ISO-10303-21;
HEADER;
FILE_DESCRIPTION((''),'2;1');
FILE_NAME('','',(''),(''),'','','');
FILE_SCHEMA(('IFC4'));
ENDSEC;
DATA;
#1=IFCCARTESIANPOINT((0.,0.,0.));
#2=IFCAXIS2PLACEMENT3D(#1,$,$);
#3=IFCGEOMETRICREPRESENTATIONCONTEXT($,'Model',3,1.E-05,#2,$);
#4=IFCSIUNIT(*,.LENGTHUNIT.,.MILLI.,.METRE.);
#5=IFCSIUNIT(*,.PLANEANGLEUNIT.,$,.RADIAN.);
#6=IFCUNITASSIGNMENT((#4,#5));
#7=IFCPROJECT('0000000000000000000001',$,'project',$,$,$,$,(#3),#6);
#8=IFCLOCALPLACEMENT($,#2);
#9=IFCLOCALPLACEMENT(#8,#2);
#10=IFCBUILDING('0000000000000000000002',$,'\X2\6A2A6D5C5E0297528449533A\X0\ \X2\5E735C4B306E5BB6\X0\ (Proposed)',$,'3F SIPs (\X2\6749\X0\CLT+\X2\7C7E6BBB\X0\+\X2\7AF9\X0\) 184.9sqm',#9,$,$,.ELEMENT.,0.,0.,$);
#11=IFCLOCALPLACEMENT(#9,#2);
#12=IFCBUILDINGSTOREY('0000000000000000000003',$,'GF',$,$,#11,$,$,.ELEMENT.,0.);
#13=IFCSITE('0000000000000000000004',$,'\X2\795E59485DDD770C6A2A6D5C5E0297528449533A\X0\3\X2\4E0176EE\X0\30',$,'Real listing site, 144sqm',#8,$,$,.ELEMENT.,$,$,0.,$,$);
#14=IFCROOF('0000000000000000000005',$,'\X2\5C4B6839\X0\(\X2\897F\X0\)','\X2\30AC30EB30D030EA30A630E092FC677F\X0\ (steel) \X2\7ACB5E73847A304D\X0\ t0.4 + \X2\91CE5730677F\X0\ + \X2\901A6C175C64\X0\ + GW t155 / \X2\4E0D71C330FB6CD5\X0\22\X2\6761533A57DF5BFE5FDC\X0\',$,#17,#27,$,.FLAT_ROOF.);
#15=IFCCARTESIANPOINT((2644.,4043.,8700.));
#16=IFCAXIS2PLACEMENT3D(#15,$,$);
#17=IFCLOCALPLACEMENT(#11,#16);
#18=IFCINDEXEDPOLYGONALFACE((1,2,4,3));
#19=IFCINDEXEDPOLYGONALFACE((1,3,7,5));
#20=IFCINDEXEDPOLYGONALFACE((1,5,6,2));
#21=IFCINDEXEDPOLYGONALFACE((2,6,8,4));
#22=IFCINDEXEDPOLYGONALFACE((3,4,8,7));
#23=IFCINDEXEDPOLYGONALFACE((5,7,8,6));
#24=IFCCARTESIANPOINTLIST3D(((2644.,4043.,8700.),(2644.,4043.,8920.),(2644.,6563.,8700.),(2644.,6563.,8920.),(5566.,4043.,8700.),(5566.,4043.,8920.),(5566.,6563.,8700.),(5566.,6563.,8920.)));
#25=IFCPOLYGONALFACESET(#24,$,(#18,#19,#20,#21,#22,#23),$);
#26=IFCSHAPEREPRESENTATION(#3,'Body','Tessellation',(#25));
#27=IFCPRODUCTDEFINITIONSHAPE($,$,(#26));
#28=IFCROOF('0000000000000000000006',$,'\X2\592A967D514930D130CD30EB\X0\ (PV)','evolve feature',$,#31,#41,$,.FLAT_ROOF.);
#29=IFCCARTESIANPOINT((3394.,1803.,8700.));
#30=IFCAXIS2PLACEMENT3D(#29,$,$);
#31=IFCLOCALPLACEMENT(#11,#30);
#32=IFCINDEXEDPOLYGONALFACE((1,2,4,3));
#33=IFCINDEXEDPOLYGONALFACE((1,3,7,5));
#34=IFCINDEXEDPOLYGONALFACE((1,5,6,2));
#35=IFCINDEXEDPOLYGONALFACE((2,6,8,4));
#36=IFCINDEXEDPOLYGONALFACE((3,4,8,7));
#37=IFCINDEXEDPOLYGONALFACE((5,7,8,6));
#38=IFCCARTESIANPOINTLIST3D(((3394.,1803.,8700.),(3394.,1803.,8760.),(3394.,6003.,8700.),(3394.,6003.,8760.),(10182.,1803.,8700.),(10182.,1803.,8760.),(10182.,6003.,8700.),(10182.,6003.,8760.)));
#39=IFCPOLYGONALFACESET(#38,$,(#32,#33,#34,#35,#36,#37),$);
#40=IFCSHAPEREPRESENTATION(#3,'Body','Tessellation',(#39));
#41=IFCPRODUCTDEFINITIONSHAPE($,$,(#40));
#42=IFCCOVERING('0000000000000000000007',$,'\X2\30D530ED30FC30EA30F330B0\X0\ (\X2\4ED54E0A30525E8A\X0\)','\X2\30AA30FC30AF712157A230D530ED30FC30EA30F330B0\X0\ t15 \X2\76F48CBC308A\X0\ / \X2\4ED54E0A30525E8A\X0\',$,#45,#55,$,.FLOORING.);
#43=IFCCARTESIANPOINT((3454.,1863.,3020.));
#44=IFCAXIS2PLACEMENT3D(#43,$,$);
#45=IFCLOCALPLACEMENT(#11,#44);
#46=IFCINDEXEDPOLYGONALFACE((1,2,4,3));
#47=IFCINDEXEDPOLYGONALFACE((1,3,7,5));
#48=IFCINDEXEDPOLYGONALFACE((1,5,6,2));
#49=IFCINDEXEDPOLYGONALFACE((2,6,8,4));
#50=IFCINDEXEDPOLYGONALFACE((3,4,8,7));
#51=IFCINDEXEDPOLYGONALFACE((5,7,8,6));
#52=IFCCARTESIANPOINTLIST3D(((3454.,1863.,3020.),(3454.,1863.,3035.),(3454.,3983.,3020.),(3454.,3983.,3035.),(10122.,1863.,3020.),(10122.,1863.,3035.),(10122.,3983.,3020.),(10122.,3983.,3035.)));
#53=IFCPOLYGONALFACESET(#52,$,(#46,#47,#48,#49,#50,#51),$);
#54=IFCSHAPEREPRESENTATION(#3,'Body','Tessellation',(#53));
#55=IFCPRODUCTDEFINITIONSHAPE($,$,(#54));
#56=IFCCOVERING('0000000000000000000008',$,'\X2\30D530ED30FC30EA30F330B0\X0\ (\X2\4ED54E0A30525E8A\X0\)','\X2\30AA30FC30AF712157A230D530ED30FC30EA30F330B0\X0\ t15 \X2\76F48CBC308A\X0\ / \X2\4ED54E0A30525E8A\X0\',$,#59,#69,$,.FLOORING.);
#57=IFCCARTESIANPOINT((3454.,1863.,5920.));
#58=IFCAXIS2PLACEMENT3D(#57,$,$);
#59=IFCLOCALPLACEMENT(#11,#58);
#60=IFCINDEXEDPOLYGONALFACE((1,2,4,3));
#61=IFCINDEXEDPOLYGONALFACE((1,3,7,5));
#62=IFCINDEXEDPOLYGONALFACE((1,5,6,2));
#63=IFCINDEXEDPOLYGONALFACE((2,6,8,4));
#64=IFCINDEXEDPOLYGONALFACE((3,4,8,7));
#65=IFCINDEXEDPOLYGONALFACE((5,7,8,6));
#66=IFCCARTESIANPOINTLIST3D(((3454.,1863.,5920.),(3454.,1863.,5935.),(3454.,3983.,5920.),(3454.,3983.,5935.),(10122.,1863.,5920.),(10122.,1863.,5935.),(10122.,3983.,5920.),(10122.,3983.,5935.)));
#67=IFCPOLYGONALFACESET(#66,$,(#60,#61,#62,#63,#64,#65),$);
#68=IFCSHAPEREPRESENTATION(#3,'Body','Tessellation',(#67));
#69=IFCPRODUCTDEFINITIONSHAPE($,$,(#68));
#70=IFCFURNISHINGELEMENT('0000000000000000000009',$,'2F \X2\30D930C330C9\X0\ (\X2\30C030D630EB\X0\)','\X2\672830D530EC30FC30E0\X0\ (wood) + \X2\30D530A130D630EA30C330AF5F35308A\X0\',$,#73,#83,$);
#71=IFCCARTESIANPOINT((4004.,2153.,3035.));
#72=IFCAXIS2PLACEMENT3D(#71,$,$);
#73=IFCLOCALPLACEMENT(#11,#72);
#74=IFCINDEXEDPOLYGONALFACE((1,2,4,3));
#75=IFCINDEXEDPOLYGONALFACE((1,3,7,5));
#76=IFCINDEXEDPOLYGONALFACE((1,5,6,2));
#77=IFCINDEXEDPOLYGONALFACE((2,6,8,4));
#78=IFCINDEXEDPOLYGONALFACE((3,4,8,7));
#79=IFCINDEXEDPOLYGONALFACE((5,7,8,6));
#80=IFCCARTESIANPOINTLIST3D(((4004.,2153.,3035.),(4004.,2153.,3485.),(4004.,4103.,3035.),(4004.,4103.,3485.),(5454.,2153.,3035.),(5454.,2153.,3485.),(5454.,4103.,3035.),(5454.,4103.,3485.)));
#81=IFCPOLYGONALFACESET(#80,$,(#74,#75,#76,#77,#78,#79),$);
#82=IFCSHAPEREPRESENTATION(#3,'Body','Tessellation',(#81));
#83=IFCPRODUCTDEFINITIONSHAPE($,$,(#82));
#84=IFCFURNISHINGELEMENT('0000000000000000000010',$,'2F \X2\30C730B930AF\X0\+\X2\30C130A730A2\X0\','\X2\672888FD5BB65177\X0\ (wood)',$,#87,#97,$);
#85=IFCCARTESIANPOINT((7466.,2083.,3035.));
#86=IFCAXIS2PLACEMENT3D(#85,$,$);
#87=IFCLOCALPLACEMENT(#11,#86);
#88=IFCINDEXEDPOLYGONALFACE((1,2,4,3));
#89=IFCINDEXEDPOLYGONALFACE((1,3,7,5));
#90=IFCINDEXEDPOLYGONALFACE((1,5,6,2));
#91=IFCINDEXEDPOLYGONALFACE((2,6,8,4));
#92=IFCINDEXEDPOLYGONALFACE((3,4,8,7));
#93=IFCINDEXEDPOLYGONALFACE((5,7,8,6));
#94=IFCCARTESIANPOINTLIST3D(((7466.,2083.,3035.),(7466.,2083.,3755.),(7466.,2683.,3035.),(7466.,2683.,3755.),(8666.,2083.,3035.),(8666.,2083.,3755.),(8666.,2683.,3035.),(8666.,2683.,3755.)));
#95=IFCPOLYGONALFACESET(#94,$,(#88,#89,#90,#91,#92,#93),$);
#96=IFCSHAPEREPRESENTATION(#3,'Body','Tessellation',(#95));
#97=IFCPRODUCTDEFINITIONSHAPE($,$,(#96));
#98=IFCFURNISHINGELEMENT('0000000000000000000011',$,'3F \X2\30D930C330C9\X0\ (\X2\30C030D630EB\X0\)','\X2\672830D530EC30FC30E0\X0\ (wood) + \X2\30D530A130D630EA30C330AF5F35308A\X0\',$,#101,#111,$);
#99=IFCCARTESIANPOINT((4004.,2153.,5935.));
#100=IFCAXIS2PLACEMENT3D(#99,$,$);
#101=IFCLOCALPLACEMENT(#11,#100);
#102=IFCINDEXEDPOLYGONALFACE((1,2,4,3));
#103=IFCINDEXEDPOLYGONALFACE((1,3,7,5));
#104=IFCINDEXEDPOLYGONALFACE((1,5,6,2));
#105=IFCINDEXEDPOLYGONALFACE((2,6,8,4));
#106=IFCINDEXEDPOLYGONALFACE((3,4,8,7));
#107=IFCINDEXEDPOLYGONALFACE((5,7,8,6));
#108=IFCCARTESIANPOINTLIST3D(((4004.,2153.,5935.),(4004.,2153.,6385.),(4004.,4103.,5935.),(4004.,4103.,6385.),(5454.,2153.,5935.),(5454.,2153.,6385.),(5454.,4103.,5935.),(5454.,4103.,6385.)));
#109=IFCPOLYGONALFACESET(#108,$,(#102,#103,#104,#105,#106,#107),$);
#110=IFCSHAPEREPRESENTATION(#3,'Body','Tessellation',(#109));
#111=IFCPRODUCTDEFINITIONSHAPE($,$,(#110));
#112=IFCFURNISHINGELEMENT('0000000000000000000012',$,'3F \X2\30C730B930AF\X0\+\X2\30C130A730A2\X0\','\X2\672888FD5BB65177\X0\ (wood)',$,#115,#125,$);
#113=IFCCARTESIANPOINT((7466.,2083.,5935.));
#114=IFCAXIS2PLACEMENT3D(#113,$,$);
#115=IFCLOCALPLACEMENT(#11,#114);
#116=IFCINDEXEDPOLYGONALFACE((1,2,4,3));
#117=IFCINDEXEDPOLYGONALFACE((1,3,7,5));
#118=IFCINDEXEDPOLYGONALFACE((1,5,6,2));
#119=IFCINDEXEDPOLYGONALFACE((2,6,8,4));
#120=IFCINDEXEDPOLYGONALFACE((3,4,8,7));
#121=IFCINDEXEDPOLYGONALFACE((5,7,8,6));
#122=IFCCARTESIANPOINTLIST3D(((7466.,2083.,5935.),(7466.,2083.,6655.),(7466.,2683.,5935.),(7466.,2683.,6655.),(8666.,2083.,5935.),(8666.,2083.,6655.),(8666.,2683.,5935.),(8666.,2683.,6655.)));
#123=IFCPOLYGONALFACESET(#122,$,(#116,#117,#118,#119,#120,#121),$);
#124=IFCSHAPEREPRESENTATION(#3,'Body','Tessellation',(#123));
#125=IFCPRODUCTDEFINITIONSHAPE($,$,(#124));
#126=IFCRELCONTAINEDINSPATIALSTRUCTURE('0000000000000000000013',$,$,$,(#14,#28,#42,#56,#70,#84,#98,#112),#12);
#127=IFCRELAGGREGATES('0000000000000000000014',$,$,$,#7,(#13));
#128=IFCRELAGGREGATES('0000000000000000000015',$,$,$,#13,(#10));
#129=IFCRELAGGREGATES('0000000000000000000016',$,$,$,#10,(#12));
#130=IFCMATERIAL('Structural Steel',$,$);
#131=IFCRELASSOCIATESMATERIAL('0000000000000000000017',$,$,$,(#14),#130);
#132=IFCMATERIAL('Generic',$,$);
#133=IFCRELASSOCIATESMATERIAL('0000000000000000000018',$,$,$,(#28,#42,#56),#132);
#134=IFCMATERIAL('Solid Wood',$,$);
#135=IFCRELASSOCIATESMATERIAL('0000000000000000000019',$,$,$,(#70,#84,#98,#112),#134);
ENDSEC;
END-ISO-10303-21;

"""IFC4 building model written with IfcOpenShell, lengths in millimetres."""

from ifc_helpers import new_model, si_unit, frame, frame_2d, origin, place, context, project, spatial, rectangle, extrude, material, element, save


model = new_model("IFC4")

# Units and contexts
model_context = context("Model", 3, precision=1e-05, world=origin())
ifc_project = project(units=[si_unit("LENGTHUNIT", "METRE", prefix="MILLI"), si_unit("PLANEANGLEUNIT", "RADIAN")], contexts=[model_context])

# Site, building, storey
site_placement = place(None, origin())
site = spatial("IfcSite", under=ifc_project, at=site_placement, Name="神奈川県横浜市青葉区3丁目30", ObjectType="Real listing site, 144sqm", CompositionType="ELEMENT", RefElevation=0.0)
building_placement = place(site_placement, origin())
building = spatial("IfcBuilding", under=site, at=building_placement, Name="横浜市青葉区 平屋の家 (Proposed)", ObjectType="3F SIPs (杉CLT+籾殻+竹) 184.9sqm", CompositionType="ELEMENT", ElevationOfRefHeight=0.0, ElevationOfTerrain=0.0)
storey_placement = place(building_placement, origin())
storey = spatial("IfcBuildingStorey", under=building, at=storey_placement, Name="GF", CompositionType="ELEMENT", Elevation=0.0)

# Shared definitions
ifc_material_1 = material(Name="Solid Wood")

# Roofs
ifc_material_2 = material(Name="Structural Steel")
roof_1_placement = place(storey_placement, frame((2644.0, 4043.0, 8700.0)))
element("IfcRoof", 1, at=roof_1_placement, inside=storey, material=ifc_material_2, Name="屋根(西)", Description="ガルバリウム鋼板 (steel) 立平葺き t0.4 + 野地板 + 通気層 + GW t155 / 不燃・法22条区域対応", PredefinedType="FLAT_ROOF", context=model_context, shape_type="SweptSolid", body=[
    extrude(rectangle(XDim=2922.0, YDim=2520.0, at=frame_2d((1461.0, 1260.0))), frame((2644.0, 4043.0, 8700.0)), (0.0, 0.0, 1.0), 220.0),
])
ifc_material_3 = material(Name="Generic")
roof_2_placement = place(storey_placement, frame((3394.0, 1803.0, 8700.0)))
element("IfcRoof", 2, at=roof_2_placement, inside=storey, material=ifc_material_3, Name="太陽光パネル (PV)", Description="evolve feature", PredefinedType="FLAT_ROOF", context=model_context, shape_type="SweptSolid", body=[
    extrude(rectangle(XDim=6788.0, YDim=4200.0, at=frame_2d((3394.0, 2100.0))), frame((3394.0, 1803.0, 8700.0)), (0.0, 0.0, 1.0), 60.0),
])

# Coverings
covering_1_placement = place(storey_placement, frame((3454.0, 1863.0, 3020.0)))
element("IfcCovering", 3, at=covering_1_placement, inside=storey, material=ifc_material_3, Name="フローリング (仕上げ床)", Description="オーク無垢フローリング t15 直貼り / 仕上げ床", PredefinedType="FLOORING", context=model_context, shape_type="SweptSolid", body=[
    extrude(rectangle(XDim=6668.0, YDim=2120.0, at=frame_2d((3334.0, 1060.0))), frame((3454.0, 1863.0, 3020.0)), (0.0, 0.0, 1.0), 15.0),
])
covering_2_placement = place(storey_placement, frame((3454.0, 1863.0, 5920.0)))
element("IfcCovering", 4, at=covering_2_placement, inside=storey, material=ifc_material_3, Name="フローリング (仕上げ床)", Description="オーク無垢フローリング t15 直貼り / 仕上げ床", PredefinedType="FLOORING", context=model_context, shape_type="SweptSolid", body=[
    extrude(rectangle(XDim=6668.0, YDim=2120.0, at=frame_2d((3334.0, 1060.0))), frame((3454.0, 1863.0, 5920.0)), (0.0, 0.0, 1.0), 15.0),
])

# Furnishing elements
furnishing_1_placement = place(storey_placement, frame((4004.0, 2153.0, 3035.0)))
element("IfcFurnishingElement", 5, at=furnishing_1_placement, inside=storey, material=ifc_material_1, Name="2F ベッド (ダブル)", Description="木フレーム (wood) + ファブリック張り", context=model_context, shape_type="SweptSolid", body=[
    extrude(rectangle(XDim=1450.0, YDim=1950.0, at=frame_2d((725.0, 975.0))), frame((4004.0, 2153.0, 3035.0)), (0.0, 0.0, 1.0), 450.0),
])
furnishing_2_placement = place(storey_placement, frame((7466.0, 2083.0, 3035.0)))
element("IfcFurnishingElement", 6, at=furnishing_2_placement, inside=storey, material=ifc_material_1, Name="2F デスク+チェア", Description="木製家具 (wood)", context=model_context, shape_type="SweptSolid", body=[
    extrude(rectangle(XDim=1200.0, YDim=600.0, at=frame_2d((600.0, 300.0))), frame((7466.0, 2083.0, 3035.0)), (0.0, 0.0, 1.0), 720.0),
])
furnishing_3_placement = place(storey_placement, frame((4004.0, 2153.0, 5935.0)))
element("IfcFurnishingElement", 7, at=furnishing_3_placement, inside=storey, material=ifc_material_1, Name="3F ベッド (ダブル)", Description="木フレーム (wood) + ファブリック張り", context=model_context, shape_type="SweptSolid", body=[
    extrude(rectangle(XDim=1450.0, YDim=1950.0, at=frame_2d((725.0, 975.0))), frame((4004.0, 2153.0, 5935.0)), (0.0, 0.0, 1.0), 450.0),
])
furnishing_4_placement = place(storey_placement, frame((7466.0, 2083.0, 5935.0)))
element("IfcFurnishingElement", 8, at=furnishing_4_placement, inside=storey, material=ifc_material_1, Name="3F デスク+チェア", Description="木製家具 (wood)", context=model_context, shape_type="SweptSolid", body=[
    extrude(rectangle(XDim=1200.0, YDim=600.0, at=frame_2d((600.0, 300.0))), frame((7466.0, 2083.0, 5935.0)), (0.0, 0.0, 1.0), 720.0),
])

save(model, "model.ifc")
